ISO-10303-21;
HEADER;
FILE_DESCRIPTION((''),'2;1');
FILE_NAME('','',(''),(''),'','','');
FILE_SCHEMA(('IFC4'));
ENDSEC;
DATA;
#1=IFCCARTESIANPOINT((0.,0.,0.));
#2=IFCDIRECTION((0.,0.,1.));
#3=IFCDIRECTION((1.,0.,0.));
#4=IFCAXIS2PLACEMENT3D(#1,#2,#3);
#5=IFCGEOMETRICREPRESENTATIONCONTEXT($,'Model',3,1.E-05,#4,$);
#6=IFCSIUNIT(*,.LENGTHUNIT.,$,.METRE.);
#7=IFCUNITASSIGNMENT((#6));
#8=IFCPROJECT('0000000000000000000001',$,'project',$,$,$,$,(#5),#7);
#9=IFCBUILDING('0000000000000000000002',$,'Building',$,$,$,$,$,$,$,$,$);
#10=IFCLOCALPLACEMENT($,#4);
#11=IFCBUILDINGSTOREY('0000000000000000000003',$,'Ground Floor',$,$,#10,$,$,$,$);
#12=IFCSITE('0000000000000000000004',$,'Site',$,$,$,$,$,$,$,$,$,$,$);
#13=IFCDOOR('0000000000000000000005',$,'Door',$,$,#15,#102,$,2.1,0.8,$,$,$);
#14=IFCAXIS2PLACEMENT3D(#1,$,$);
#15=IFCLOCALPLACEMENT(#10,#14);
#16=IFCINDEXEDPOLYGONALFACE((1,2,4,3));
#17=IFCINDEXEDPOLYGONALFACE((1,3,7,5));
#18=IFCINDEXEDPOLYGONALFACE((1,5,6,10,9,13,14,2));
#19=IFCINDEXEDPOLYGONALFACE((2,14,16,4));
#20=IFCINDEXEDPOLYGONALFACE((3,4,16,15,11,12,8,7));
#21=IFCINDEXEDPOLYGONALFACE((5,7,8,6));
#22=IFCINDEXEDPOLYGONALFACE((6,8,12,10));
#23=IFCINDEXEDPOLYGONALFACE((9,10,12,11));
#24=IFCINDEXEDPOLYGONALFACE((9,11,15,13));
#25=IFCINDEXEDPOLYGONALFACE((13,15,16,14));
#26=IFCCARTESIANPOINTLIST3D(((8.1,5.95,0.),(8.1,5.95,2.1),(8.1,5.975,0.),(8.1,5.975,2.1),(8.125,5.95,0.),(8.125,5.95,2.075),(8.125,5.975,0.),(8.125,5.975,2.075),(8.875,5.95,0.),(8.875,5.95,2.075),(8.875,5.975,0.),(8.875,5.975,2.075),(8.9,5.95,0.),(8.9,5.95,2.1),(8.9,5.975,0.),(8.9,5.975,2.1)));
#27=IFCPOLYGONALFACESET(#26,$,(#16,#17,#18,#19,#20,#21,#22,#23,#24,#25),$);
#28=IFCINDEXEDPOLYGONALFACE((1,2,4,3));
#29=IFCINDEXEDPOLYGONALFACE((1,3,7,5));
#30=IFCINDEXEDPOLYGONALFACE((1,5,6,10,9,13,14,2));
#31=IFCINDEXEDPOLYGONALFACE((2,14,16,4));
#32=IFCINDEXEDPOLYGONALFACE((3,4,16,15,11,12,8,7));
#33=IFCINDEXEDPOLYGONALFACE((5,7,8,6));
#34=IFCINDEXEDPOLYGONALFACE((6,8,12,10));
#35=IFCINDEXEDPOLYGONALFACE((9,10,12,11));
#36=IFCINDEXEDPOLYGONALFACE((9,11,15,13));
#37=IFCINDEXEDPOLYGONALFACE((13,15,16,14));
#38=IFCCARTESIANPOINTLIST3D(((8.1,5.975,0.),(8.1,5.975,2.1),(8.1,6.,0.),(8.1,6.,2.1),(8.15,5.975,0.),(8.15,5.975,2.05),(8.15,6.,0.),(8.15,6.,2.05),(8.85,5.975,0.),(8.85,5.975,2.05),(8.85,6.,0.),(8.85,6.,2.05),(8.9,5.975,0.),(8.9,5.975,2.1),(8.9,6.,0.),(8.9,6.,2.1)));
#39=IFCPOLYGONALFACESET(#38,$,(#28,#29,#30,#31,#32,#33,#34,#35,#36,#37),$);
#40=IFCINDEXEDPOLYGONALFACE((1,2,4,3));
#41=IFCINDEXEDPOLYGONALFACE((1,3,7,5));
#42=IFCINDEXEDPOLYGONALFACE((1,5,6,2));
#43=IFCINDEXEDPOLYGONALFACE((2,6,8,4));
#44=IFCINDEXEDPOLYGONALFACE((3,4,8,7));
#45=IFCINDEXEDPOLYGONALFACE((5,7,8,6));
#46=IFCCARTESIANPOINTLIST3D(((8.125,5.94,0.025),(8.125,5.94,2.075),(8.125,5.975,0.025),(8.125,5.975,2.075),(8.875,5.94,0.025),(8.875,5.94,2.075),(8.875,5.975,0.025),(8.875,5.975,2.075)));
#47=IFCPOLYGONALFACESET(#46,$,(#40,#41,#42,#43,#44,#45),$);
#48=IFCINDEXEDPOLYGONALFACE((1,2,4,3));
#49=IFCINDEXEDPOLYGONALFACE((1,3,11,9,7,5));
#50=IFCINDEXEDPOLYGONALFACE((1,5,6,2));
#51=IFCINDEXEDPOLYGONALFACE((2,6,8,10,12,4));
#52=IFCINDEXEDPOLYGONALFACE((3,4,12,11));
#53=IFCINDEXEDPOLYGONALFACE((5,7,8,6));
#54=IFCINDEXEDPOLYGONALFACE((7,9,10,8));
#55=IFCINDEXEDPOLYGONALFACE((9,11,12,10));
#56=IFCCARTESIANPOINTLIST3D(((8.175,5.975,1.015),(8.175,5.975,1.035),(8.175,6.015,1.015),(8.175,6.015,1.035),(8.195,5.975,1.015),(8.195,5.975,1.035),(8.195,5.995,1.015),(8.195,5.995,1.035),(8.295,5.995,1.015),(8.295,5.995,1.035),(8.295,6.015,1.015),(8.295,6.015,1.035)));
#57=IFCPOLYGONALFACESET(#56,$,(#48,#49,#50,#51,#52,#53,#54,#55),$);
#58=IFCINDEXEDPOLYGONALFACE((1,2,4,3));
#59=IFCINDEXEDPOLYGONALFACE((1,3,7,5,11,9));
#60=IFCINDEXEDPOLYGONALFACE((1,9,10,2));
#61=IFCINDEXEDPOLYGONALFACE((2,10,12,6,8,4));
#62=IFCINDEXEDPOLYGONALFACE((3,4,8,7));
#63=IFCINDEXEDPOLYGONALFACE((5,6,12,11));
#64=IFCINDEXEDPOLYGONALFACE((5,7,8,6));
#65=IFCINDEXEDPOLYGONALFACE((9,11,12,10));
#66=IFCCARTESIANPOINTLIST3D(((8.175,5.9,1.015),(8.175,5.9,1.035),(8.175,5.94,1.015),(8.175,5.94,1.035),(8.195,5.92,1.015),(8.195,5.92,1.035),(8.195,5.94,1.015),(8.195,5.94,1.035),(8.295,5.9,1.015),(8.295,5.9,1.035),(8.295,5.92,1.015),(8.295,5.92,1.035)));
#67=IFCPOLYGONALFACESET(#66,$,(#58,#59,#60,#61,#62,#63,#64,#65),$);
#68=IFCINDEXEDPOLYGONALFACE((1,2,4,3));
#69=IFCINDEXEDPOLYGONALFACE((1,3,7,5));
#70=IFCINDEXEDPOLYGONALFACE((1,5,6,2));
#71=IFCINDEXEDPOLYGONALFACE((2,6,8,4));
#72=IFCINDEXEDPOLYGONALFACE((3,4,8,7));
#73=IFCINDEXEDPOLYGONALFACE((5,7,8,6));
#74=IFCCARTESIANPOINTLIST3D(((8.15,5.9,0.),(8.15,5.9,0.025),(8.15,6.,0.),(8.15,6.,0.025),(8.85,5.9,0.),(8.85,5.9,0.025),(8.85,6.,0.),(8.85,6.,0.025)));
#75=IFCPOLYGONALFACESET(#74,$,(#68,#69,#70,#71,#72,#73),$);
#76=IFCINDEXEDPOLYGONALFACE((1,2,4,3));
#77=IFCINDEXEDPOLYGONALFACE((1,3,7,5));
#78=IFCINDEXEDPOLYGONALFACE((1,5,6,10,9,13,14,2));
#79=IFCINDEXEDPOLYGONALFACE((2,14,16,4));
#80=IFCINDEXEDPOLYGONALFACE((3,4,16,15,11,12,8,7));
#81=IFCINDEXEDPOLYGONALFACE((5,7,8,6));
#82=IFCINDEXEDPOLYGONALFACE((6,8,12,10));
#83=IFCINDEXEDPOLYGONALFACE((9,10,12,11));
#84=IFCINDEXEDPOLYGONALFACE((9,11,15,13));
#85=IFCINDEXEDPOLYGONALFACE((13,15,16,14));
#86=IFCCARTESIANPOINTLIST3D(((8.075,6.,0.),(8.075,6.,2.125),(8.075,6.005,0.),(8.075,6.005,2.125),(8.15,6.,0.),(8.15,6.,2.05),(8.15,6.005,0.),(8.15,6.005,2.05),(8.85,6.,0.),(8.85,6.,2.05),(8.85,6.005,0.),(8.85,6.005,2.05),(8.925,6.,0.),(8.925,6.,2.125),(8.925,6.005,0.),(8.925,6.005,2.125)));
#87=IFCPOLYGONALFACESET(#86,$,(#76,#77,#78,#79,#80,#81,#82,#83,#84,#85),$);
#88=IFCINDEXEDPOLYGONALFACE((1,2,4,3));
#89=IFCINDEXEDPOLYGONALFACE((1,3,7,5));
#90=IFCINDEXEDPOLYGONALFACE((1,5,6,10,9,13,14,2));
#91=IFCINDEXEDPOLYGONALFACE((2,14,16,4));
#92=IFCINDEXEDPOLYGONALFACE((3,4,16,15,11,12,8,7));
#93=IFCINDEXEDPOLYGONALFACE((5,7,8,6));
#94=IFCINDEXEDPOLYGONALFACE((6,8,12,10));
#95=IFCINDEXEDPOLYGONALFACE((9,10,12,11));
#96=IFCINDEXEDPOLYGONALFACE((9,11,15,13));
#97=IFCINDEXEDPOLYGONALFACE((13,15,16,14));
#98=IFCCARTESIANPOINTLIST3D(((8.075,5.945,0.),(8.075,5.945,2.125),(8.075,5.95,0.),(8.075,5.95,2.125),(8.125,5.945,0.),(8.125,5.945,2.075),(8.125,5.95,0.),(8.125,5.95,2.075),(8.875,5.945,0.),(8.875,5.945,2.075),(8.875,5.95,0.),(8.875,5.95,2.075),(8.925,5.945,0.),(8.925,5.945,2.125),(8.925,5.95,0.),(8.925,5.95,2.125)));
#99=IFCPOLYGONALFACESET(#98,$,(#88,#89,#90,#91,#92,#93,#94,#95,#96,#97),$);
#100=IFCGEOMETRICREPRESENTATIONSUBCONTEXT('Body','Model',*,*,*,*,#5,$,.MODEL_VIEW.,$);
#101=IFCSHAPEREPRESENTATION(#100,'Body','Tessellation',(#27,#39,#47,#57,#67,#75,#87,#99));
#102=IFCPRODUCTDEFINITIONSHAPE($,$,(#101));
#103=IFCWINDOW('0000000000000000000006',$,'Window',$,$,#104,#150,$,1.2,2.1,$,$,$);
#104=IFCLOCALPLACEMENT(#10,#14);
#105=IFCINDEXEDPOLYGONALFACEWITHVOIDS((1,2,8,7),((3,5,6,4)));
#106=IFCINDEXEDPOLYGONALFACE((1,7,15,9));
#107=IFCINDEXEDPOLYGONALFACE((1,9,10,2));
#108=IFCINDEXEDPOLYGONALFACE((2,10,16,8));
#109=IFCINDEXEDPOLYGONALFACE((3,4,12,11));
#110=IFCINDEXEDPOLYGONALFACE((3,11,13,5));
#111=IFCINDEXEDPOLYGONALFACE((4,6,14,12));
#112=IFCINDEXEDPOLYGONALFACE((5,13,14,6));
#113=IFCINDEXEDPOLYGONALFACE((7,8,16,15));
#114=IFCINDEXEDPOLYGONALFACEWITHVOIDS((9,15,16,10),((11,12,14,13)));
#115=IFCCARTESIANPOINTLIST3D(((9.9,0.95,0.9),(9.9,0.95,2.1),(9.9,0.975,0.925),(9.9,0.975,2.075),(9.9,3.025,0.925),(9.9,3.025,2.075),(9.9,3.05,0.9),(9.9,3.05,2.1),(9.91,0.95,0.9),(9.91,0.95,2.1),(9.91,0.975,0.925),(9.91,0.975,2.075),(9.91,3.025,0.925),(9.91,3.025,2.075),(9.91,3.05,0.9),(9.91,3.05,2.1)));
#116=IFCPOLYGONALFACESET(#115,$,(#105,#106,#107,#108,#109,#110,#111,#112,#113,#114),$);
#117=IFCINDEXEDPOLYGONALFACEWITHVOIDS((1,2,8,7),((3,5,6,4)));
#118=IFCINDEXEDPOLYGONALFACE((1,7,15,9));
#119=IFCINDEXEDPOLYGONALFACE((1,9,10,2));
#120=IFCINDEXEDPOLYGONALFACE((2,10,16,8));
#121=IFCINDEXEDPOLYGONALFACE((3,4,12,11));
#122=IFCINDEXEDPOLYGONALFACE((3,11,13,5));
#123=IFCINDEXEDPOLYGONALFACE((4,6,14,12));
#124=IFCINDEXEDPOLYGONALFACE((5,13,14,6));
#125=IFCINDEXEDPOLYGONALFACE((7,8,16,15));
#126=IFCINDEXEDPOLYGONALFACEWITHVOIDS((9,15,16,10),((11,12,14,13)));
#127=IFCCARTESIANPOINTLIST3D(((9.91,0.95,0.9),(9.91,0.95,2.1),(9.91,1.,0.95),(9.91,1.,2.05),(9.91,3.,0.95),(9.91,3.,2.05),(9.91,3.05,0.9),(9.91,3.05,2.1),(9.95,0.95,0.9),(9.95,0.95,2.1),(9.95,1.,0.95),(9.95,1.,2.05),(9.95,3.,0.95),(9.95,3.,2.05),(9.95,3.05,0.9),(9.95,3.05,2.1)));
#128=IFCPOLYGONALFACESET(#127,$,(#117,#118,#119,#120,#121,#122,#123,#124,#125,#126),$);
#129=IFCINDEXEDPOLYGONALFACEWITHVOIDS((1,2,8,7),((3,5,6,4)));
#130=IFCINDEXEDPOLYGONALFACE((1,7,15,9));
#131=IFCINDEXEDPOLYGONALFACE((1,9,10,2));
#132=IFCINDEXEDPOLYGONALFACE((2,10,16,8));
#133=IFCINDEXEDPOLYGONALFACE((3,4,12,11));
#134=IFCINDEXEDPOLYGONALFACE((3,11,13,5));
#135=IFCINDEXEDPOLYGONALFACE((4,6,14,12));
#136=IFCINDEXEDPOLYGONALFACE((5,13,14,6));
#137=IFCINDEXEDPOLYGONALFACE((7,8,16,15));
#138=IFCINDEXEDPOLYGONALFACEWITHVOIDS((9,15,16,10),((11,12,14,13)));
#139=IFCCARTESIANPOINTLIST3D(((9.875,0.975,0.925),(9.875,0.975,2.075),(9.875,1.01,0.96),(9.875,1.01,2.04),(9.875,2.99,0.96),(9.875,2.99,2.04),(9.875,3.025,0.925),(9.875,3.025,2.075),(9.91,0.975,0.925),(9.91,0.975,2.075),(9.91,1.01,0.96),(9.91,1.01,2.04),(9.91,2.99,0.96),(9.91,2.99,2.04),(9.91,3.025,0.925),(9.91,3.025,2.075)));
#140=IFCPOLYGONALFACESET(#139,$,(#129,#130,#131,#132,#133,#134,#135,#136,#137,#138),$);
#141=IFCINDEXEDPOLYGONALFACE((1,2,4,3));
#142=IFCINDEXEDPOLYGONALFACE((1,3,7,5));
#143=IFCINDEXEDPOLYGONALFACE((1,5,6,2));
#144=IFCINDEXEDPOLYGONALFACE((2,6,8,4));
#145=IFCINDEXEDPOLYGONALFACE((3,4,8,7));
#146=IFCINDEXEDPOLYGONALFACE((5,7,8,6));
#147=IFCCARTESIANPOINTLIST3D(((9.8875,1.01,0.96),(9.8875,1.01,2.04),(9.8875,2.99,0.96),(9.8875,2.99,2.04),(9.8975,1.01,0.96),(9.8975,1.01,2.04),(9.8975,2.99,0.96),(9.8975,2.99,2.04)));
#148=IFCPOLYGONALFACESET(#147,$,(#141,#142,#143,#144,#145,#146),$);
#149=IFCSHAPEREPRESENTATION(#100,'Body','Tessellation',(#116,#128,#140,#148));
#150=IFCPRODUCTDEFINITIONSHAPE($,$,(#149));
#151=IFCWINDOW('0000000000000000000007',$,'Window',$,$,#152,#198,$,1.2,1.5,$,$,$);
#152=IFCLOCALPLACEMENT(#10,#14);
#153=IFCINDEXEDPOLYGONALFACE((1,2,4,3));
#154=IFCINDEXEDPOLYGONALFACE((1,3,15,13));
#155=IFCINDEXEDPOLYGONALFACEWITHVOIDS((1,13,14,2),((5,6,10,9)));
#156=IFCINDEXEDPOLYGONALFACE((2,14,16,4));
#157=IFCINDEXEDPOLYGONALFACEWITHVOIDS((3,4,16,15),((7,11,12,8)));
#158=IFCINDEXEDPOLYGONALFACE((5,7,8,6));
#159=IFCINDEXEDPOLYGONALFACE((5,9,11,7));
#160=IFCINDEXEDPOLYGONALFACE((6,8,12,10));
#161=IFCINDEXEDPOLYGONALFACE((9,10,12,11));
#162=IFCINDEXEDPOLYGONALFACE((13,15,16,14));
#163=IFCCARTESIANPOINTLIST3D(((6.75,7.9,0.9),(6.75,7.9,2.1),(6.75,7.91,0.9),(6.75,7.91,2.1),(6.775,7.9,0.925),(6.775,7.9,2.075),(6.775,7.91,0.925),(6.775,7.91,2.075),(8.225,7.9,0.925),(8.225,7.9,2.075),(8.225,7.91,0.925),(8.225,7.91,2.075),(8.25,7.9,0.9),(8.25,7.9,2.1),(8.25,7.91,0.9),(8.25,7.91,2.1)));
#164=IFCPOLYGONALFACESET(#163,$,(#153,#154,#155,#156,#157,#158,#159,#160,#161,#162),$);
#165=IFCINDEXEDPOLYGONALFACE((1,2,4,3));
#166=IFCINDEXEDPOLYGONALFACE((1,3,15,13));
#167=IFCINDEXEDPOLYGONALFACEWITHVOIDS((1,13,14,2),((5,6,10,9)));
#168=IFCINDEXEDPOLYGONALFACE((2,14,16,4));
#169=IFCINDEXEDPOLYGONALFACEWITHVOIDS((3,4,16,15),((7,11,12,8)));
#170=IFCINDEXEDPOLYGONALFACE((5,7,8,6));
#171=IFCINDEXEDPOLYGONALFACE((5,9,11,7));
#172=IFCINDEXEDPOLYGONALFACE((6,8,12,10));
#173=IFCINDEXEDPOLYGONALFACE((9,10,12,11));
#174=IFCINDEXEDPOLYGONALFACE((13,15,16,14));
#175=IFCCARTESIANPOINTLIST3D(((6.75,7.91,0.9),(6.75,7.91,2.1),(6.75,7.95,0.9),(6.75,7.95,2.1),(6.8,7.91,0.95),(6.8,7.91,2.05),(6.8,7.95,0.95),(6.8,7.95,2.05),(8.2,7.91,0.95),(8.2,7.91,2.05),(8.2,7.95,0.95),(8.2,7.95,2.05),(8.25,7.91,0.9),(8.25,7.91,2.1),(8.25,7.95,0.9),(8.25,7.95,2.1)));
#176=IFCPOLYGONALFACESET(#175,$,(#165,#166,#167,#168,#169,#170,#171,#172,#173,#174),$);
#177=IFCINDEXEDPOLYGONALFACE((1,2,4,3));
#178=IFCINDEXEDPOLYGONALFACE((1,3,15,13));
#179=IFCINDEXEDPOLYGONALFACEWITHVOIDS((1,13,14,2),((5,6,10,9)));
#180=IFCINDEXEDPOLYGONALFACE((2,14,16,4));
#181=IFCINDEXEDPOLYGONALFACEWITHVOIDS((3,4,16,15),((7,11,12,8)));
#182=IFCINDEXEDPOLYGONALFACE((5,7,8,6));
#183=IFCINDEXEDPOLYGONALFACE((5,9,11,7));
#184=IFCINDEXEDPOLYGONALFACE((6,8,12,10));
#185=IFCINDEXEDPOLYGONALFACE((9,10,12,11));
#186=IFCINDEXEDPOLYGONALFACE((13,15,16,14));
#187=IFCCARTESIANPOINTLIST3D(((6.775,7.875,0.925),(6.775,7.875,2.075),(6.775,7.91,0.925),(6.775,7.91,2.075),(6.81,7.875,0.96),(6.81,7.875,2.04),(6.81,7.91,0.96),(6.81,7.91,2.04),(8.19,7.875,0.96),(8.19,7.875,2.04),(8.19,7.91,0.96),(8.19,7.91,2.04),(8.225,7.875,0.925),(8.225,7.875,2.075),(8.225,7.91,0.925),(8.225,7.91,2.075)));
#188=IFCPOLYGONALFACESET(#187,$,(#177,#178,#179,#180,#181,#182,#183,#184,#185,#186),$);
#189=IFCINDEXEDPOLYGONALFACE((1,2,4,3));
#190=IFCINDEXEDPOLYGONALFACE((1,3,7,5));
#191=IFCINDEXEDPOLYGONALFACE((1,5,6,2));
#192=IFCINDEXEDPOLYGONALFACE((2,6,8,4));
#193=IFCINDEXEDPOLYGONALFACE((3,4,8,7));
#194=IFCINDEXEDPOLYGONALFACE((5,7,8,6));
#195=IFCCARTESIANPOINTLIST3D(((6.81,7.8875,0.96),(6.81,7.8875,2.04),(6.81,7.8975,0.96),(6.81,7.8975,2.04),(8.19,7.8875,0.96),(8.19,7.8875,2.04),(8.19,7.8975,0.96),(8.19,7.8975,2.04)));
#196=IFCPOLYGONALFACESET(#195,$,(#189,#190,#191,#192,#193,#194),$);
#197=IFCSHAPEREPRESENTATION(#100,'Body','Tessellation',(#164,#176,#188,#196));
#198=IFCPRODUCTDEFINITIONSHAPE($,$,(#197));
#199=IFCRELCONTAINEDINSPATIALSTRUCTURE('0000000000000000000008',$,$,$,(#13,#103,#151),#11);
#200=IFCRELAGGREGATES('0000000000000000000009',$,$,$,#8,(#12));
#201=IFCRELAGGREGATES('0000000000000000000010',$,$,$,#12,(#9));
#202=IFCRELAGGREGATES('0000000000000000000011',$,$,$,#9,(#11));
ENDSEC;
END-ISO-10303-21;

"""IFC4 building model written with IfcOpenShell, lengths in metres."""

from ifc_helpers import new_model, si_unit, frame, origin_with_axes, place, context, subcontext, project, spatial, line, indexed_curve, outline, extrude, element, save


model = new_model("IFC4")

# Units and contexts
model_context = context("Model", 3, precision=1e-05, world=origin_with_axes())
body_context = subcontext(model_context, "Body", "Model", "MODEL_VIEW")
ifc_project = project(units=[si_unit("LENGTHUNIT", "METRE")], contexts=[model_context])

# Site, building, storey
site = spatial("IfcSite", under=ifc_project, Name="Site")
building = spatial("IfcBuilding", under=site, Name="Building")
storey_placement = place(None, origin_with_axes())
storey = spatial("IfcBuildingStorey", under=building, at=storey_placement, Name="Ground Floor")

# Door
door_1_placement = place(storey_placement, frame((8.9, 6.0, 0.0), z_axis=(0.0, 0.0, 1.0), x_axis=(-1.0, 0.0, 0.0)))
element("IfcDoor", 1, at=door_1_placement, inside=storey, Name="Door", OverallHeight=2.1, OverallWidth=0.8, context=body_context, shape_type="SweptSolid", body=[
    extrude(outline(indexed_curve([(0.0, 0.0), (0.0, 2.1), (0.8, 2.1), (0.8, 0.0), (0.775, 0.0), (0.775, 2.075), (0.025, 2.075), (0.025, 0.0)], segments=[line(1, 2, 3, 4, 5, 6, 7, 8, 1)])), frame((0.0, 0.025, 0.0), z_axis=(0.0, -1.0, 0.0), x_axis=(1.0, 0.0, 0.0)), (0.0, 0.0, -1.0), 0.025),
    extrude(outline(indexed_curve([(0.0, 0.0), (0.0, 2.1), (0.8, 2.1), (0.8, 0.0), (0.75, 0.0), (0.75, 2.05), (0.05, 2.05), (0.05, 0.0)], segments=[line(1, 2, 3, 4, 5, 6, 7, 8, 1)])), frame((0.0, 0.0, 0.0), z_axis=(0.0, -1.0, 0.0), x_axis=(1.0, 0.0, 0.0)), (0.0, 0.0, -1.0), 0.025),
    extrude(outline(indexed_curve([(0.0, 0.0), (0.75, 0.0), (0.75, 0.035), (0.0, 0.035)], segments=[line(1, 2, 3, 4, 1)])), frame((0.025, 0.025, 0.025), z_axis=(0.0, 0.0, 1.0), x_axis=(1.0, 0.0, 0.0)), (0.0, 0.0, 1.0), 2.05),
    extrude(outline(indexed_curve([(0.0, 0.0), (0.0, -0.04), (-0.12, -0.04), (-0.12, -0.02), (-0.02, -0.02), (-0.02, 0.0)], segments=[line(1, 2, 3, 4, 5, 6, 1)])), frame((0.725, 0.025, 1.015), z_axis=(0.0, 0.0, 1.0), x_axis=(1.0, 0.0, 0.0)), (0.0, 0.0, 1.0), 0.02),
    extrude(outline(indexed_curve([(0.0, 0.0), (0.0, 0.04), (-0.12, 0.04), (-0.12, 0.02), (-0.02, 0.02), (-0.02, 0.0)], segments=[line(1, 2, 3, 4, 5, 6, 1)])), frame((0.725, 0.06, 1.015), z_axis=(0.0, 0.0, 1.0), x_axis=(1.0, 0.0, 0.0)), (0.0, 0.0, 1.0), 0.02),
    extrude(outline(indexed_curve([(0.0, 0.0), (0.7, 0.0), (0.7, 0.1), (0.0, 0.1)], segments=[line(1, 2, 3, 4, 1)])), frame((0.05, 0.0, 0.0), z_axis=(0.0, 0.0, 1.0), x_axis=(1.0, 0.0, 0.0)), (0.0, 0.0, 1.0), 0.025),
    extrude(outline(indexed_curve([(0.0, 0.0), (0.0, 2.125), (0.85, 2.125), (0.85, 0.0), (0.775, 0.0), (0.775, 2.05), (0.075, 2.05), (0.075, 0.0)], segments=[line(1, 2, 3, 4, 5, 6, 7, 8, 1)])), frame((-0.025, -0.005, 0.0), z_axis=(0.0, -1.0, 0.0), x_axis=(1.0, 0.0, 0.0)), (0.0, 0.0, -1.0), 0.005),
    extrude(outline(indexed_curve([(0.0, 0.0), (0.0, 2.125), (0.85, 2.125), (0.85, 0.0), (0.8, 0.0), (0.8, 2.075), (0.05, 2.075), (0.05, 0.0)], segments=[line(1, 2, 3, 4, 5, 6, 7, 8, 1)])), frame((-0.025, 0.05, 0.0), z_axis=(0.0, -1.0, 0.0), x_axis=(1.0, 0.0, 0.0)), (0.0, 0.0, -1.0), 0.005),
])

# Windows
window_placement = place(storey_placement, frame((10.0, 0.95, 0.9), z_axis=(0.0, 0.0, 1.0), x_axis=(0.0, 1.0, 0.0)))
element("IfcWindow", 2, at=window_placement, inside=storey, Name="Window", OverallHeight=1.2, OverallWidth=2.1, context=body_context, shape_type="SweptSolid", body=[
    extrude(outline(indexed_curve([(0.0, 0.0), (2.1, 0.0), (2.1, 1.2), (0.0, 1.2)], segments=[line(1, 2, 3, 4, 1)]), holes=[indexed_curve([(0.025, 0.025), (2.075, 0.025), (2.075, 1.175), (0.025, 1.175)], segments=[line(1, 2, 3, 4, 1)])]), frame((0.0, 0.09, 0.0), z_axis=(0.0, -1.0, 0.0), x_axis=(1.0, 0.0, 0.0)), (0.0, 0.0, -1.0), 0.01),
    extrude(outline(indexed_curve([(0.0, 0.0), (2.1, 0.0), (2.1, 1.2), (0.0, 1.2)], segments=[line(1, 2, 3, 4, 1)]), holes=[indexed_curve([(0.05, 0.05), (2.05, 0.05), (2.05, 1.15), (0.05, 1.15)], segments=[line(1, 2, 3, 4, 1)])]), frame((0.0, 0.05, 0.0), z_axis=(0.0, -1.0, 0.0), x_axis=(1.0, 0.0, 0.0)), (0.0, 0.0, -1.0), 0.04),
    extrude(outline(indexed_curve([(0.0, 0.0), (2.05, 0.0), (2.05, 1.15), (0.0, 1.15)], segments=[line(1, 2, 3, 4, 1)]), holes=[indexed_curve([(0.035, 0.035), (2.015, 0.035), (2.015, 1.115), (0.035, 1.115)], segments=[line(1, 2, 3, 4, 1)])]), frame((0.025, 0.09, 0.025), z_axis=(0.0, -1.0, 0.0), x_axis=(1.0, 0.0, 0.0)), (0.0, 0.0, -1.0), 0.035),
    extrude(outline(indexed_curve([(0.035, 0.035), (2.015, 0.035), (2.015, 1.115), (0.035, 1.115)], segments=[line(1, 2, 3, 4, 1)])), frame((0.025, 0.1025, 0.025), z_axis=(0.0, -1.0, 0.0), x_axis=(1.0, 0.0, 0.0)), (0.0, 0.0, -1.0), 0.01),
])
for number, where, z_axis, x_axis, name in (
    (3, (8.25, 8.0, 0.9), (0.0, 0.0, 1.0), (-1.0, 0.0, 0.0), "Window"),
):
    element("IfcWindow", number, at=place(storey_placement, frame(where, z_axis=z_axis, x_axis=x_axis)), inside=storey, Name=name, OverallHeight=1.2, OverallWidth=1.5, context=body_context, shape_type="SweptSolid", body=[
        extrude(outline(indexed_curve([(0.0, 0.0), (1.5, 0.0), (1.5, 1.2), (0.0, 1.2)], segments=[line(1, 2, 3, 4, 1)]), holes=[indexed_curve([(0.025, 0.025), (1.475, 0.025), (1.475, 1.175), (0.025, 1.175)], segments=[line(1, 2, 3, 4, 1)])]), frame((0.0, 0.09, 0.0), z_axis=(0.0, -1.0, 0.0), x_axis=(1.0, 0.0, 0.0)), (0.0, 0.0, -1.0), 0.01),
        extrude(outline(indexed_curve([(0.0, 0.0), (1.5, 0.0), (1.5, 1.2), (0.0, 1.2)], segments=[line(1, 2, 3, 4, 1)]), holes=[indexed_curve([(0.05, 0.05), (1.45, 0.05), (1.45, 1.15), (0.05, 1.15)], segments=[line(1, 2, 3, 4, 1)])]), frame((0.0, 0.05, 0.0), z_axis=(0.0, -1.0, 0.0), x_axis=(1.0, 0.0, 0.0)), (0.0, 0.0, -1.0), 0.04),
        extrude(outline(indexed_curve([(0.0, 0.0), (1.45, 0.0), (1.45, 1.15), (0.0, 1.15)], segments=[line(1, 2, 3, 4, 1)]), holes=[indexed_curve([(0.035, 0.035), (1.415, 0.035), (1.415, 1.115), (0.035, 1.115)], segments=[line(1, 2, 3, 4, 1)])]), frame((0.025, 0.09, 0.025), z_axis=(0.0, -1.0, 0.0), x_axis=(1.0, 0.0, 0.0)), (0.0, 0.0, -1.0), 0.035),
        extrude(outline(indexed_curve([(0.035, 0.035), (1.415, 0.035), (1.415, 1.115), (0.035, 1.115)], segments=[line(1, 2, 3, 4, 1)])), frame((0.025, 0.1025, 0.025), z_axis=(0.0, -1.0, 0.0), x_axis=(1.0, 0.0, 0.0)), (0.0, 0.0, -1.0), 0.01),
    ])

save(model, "model.ifc")
